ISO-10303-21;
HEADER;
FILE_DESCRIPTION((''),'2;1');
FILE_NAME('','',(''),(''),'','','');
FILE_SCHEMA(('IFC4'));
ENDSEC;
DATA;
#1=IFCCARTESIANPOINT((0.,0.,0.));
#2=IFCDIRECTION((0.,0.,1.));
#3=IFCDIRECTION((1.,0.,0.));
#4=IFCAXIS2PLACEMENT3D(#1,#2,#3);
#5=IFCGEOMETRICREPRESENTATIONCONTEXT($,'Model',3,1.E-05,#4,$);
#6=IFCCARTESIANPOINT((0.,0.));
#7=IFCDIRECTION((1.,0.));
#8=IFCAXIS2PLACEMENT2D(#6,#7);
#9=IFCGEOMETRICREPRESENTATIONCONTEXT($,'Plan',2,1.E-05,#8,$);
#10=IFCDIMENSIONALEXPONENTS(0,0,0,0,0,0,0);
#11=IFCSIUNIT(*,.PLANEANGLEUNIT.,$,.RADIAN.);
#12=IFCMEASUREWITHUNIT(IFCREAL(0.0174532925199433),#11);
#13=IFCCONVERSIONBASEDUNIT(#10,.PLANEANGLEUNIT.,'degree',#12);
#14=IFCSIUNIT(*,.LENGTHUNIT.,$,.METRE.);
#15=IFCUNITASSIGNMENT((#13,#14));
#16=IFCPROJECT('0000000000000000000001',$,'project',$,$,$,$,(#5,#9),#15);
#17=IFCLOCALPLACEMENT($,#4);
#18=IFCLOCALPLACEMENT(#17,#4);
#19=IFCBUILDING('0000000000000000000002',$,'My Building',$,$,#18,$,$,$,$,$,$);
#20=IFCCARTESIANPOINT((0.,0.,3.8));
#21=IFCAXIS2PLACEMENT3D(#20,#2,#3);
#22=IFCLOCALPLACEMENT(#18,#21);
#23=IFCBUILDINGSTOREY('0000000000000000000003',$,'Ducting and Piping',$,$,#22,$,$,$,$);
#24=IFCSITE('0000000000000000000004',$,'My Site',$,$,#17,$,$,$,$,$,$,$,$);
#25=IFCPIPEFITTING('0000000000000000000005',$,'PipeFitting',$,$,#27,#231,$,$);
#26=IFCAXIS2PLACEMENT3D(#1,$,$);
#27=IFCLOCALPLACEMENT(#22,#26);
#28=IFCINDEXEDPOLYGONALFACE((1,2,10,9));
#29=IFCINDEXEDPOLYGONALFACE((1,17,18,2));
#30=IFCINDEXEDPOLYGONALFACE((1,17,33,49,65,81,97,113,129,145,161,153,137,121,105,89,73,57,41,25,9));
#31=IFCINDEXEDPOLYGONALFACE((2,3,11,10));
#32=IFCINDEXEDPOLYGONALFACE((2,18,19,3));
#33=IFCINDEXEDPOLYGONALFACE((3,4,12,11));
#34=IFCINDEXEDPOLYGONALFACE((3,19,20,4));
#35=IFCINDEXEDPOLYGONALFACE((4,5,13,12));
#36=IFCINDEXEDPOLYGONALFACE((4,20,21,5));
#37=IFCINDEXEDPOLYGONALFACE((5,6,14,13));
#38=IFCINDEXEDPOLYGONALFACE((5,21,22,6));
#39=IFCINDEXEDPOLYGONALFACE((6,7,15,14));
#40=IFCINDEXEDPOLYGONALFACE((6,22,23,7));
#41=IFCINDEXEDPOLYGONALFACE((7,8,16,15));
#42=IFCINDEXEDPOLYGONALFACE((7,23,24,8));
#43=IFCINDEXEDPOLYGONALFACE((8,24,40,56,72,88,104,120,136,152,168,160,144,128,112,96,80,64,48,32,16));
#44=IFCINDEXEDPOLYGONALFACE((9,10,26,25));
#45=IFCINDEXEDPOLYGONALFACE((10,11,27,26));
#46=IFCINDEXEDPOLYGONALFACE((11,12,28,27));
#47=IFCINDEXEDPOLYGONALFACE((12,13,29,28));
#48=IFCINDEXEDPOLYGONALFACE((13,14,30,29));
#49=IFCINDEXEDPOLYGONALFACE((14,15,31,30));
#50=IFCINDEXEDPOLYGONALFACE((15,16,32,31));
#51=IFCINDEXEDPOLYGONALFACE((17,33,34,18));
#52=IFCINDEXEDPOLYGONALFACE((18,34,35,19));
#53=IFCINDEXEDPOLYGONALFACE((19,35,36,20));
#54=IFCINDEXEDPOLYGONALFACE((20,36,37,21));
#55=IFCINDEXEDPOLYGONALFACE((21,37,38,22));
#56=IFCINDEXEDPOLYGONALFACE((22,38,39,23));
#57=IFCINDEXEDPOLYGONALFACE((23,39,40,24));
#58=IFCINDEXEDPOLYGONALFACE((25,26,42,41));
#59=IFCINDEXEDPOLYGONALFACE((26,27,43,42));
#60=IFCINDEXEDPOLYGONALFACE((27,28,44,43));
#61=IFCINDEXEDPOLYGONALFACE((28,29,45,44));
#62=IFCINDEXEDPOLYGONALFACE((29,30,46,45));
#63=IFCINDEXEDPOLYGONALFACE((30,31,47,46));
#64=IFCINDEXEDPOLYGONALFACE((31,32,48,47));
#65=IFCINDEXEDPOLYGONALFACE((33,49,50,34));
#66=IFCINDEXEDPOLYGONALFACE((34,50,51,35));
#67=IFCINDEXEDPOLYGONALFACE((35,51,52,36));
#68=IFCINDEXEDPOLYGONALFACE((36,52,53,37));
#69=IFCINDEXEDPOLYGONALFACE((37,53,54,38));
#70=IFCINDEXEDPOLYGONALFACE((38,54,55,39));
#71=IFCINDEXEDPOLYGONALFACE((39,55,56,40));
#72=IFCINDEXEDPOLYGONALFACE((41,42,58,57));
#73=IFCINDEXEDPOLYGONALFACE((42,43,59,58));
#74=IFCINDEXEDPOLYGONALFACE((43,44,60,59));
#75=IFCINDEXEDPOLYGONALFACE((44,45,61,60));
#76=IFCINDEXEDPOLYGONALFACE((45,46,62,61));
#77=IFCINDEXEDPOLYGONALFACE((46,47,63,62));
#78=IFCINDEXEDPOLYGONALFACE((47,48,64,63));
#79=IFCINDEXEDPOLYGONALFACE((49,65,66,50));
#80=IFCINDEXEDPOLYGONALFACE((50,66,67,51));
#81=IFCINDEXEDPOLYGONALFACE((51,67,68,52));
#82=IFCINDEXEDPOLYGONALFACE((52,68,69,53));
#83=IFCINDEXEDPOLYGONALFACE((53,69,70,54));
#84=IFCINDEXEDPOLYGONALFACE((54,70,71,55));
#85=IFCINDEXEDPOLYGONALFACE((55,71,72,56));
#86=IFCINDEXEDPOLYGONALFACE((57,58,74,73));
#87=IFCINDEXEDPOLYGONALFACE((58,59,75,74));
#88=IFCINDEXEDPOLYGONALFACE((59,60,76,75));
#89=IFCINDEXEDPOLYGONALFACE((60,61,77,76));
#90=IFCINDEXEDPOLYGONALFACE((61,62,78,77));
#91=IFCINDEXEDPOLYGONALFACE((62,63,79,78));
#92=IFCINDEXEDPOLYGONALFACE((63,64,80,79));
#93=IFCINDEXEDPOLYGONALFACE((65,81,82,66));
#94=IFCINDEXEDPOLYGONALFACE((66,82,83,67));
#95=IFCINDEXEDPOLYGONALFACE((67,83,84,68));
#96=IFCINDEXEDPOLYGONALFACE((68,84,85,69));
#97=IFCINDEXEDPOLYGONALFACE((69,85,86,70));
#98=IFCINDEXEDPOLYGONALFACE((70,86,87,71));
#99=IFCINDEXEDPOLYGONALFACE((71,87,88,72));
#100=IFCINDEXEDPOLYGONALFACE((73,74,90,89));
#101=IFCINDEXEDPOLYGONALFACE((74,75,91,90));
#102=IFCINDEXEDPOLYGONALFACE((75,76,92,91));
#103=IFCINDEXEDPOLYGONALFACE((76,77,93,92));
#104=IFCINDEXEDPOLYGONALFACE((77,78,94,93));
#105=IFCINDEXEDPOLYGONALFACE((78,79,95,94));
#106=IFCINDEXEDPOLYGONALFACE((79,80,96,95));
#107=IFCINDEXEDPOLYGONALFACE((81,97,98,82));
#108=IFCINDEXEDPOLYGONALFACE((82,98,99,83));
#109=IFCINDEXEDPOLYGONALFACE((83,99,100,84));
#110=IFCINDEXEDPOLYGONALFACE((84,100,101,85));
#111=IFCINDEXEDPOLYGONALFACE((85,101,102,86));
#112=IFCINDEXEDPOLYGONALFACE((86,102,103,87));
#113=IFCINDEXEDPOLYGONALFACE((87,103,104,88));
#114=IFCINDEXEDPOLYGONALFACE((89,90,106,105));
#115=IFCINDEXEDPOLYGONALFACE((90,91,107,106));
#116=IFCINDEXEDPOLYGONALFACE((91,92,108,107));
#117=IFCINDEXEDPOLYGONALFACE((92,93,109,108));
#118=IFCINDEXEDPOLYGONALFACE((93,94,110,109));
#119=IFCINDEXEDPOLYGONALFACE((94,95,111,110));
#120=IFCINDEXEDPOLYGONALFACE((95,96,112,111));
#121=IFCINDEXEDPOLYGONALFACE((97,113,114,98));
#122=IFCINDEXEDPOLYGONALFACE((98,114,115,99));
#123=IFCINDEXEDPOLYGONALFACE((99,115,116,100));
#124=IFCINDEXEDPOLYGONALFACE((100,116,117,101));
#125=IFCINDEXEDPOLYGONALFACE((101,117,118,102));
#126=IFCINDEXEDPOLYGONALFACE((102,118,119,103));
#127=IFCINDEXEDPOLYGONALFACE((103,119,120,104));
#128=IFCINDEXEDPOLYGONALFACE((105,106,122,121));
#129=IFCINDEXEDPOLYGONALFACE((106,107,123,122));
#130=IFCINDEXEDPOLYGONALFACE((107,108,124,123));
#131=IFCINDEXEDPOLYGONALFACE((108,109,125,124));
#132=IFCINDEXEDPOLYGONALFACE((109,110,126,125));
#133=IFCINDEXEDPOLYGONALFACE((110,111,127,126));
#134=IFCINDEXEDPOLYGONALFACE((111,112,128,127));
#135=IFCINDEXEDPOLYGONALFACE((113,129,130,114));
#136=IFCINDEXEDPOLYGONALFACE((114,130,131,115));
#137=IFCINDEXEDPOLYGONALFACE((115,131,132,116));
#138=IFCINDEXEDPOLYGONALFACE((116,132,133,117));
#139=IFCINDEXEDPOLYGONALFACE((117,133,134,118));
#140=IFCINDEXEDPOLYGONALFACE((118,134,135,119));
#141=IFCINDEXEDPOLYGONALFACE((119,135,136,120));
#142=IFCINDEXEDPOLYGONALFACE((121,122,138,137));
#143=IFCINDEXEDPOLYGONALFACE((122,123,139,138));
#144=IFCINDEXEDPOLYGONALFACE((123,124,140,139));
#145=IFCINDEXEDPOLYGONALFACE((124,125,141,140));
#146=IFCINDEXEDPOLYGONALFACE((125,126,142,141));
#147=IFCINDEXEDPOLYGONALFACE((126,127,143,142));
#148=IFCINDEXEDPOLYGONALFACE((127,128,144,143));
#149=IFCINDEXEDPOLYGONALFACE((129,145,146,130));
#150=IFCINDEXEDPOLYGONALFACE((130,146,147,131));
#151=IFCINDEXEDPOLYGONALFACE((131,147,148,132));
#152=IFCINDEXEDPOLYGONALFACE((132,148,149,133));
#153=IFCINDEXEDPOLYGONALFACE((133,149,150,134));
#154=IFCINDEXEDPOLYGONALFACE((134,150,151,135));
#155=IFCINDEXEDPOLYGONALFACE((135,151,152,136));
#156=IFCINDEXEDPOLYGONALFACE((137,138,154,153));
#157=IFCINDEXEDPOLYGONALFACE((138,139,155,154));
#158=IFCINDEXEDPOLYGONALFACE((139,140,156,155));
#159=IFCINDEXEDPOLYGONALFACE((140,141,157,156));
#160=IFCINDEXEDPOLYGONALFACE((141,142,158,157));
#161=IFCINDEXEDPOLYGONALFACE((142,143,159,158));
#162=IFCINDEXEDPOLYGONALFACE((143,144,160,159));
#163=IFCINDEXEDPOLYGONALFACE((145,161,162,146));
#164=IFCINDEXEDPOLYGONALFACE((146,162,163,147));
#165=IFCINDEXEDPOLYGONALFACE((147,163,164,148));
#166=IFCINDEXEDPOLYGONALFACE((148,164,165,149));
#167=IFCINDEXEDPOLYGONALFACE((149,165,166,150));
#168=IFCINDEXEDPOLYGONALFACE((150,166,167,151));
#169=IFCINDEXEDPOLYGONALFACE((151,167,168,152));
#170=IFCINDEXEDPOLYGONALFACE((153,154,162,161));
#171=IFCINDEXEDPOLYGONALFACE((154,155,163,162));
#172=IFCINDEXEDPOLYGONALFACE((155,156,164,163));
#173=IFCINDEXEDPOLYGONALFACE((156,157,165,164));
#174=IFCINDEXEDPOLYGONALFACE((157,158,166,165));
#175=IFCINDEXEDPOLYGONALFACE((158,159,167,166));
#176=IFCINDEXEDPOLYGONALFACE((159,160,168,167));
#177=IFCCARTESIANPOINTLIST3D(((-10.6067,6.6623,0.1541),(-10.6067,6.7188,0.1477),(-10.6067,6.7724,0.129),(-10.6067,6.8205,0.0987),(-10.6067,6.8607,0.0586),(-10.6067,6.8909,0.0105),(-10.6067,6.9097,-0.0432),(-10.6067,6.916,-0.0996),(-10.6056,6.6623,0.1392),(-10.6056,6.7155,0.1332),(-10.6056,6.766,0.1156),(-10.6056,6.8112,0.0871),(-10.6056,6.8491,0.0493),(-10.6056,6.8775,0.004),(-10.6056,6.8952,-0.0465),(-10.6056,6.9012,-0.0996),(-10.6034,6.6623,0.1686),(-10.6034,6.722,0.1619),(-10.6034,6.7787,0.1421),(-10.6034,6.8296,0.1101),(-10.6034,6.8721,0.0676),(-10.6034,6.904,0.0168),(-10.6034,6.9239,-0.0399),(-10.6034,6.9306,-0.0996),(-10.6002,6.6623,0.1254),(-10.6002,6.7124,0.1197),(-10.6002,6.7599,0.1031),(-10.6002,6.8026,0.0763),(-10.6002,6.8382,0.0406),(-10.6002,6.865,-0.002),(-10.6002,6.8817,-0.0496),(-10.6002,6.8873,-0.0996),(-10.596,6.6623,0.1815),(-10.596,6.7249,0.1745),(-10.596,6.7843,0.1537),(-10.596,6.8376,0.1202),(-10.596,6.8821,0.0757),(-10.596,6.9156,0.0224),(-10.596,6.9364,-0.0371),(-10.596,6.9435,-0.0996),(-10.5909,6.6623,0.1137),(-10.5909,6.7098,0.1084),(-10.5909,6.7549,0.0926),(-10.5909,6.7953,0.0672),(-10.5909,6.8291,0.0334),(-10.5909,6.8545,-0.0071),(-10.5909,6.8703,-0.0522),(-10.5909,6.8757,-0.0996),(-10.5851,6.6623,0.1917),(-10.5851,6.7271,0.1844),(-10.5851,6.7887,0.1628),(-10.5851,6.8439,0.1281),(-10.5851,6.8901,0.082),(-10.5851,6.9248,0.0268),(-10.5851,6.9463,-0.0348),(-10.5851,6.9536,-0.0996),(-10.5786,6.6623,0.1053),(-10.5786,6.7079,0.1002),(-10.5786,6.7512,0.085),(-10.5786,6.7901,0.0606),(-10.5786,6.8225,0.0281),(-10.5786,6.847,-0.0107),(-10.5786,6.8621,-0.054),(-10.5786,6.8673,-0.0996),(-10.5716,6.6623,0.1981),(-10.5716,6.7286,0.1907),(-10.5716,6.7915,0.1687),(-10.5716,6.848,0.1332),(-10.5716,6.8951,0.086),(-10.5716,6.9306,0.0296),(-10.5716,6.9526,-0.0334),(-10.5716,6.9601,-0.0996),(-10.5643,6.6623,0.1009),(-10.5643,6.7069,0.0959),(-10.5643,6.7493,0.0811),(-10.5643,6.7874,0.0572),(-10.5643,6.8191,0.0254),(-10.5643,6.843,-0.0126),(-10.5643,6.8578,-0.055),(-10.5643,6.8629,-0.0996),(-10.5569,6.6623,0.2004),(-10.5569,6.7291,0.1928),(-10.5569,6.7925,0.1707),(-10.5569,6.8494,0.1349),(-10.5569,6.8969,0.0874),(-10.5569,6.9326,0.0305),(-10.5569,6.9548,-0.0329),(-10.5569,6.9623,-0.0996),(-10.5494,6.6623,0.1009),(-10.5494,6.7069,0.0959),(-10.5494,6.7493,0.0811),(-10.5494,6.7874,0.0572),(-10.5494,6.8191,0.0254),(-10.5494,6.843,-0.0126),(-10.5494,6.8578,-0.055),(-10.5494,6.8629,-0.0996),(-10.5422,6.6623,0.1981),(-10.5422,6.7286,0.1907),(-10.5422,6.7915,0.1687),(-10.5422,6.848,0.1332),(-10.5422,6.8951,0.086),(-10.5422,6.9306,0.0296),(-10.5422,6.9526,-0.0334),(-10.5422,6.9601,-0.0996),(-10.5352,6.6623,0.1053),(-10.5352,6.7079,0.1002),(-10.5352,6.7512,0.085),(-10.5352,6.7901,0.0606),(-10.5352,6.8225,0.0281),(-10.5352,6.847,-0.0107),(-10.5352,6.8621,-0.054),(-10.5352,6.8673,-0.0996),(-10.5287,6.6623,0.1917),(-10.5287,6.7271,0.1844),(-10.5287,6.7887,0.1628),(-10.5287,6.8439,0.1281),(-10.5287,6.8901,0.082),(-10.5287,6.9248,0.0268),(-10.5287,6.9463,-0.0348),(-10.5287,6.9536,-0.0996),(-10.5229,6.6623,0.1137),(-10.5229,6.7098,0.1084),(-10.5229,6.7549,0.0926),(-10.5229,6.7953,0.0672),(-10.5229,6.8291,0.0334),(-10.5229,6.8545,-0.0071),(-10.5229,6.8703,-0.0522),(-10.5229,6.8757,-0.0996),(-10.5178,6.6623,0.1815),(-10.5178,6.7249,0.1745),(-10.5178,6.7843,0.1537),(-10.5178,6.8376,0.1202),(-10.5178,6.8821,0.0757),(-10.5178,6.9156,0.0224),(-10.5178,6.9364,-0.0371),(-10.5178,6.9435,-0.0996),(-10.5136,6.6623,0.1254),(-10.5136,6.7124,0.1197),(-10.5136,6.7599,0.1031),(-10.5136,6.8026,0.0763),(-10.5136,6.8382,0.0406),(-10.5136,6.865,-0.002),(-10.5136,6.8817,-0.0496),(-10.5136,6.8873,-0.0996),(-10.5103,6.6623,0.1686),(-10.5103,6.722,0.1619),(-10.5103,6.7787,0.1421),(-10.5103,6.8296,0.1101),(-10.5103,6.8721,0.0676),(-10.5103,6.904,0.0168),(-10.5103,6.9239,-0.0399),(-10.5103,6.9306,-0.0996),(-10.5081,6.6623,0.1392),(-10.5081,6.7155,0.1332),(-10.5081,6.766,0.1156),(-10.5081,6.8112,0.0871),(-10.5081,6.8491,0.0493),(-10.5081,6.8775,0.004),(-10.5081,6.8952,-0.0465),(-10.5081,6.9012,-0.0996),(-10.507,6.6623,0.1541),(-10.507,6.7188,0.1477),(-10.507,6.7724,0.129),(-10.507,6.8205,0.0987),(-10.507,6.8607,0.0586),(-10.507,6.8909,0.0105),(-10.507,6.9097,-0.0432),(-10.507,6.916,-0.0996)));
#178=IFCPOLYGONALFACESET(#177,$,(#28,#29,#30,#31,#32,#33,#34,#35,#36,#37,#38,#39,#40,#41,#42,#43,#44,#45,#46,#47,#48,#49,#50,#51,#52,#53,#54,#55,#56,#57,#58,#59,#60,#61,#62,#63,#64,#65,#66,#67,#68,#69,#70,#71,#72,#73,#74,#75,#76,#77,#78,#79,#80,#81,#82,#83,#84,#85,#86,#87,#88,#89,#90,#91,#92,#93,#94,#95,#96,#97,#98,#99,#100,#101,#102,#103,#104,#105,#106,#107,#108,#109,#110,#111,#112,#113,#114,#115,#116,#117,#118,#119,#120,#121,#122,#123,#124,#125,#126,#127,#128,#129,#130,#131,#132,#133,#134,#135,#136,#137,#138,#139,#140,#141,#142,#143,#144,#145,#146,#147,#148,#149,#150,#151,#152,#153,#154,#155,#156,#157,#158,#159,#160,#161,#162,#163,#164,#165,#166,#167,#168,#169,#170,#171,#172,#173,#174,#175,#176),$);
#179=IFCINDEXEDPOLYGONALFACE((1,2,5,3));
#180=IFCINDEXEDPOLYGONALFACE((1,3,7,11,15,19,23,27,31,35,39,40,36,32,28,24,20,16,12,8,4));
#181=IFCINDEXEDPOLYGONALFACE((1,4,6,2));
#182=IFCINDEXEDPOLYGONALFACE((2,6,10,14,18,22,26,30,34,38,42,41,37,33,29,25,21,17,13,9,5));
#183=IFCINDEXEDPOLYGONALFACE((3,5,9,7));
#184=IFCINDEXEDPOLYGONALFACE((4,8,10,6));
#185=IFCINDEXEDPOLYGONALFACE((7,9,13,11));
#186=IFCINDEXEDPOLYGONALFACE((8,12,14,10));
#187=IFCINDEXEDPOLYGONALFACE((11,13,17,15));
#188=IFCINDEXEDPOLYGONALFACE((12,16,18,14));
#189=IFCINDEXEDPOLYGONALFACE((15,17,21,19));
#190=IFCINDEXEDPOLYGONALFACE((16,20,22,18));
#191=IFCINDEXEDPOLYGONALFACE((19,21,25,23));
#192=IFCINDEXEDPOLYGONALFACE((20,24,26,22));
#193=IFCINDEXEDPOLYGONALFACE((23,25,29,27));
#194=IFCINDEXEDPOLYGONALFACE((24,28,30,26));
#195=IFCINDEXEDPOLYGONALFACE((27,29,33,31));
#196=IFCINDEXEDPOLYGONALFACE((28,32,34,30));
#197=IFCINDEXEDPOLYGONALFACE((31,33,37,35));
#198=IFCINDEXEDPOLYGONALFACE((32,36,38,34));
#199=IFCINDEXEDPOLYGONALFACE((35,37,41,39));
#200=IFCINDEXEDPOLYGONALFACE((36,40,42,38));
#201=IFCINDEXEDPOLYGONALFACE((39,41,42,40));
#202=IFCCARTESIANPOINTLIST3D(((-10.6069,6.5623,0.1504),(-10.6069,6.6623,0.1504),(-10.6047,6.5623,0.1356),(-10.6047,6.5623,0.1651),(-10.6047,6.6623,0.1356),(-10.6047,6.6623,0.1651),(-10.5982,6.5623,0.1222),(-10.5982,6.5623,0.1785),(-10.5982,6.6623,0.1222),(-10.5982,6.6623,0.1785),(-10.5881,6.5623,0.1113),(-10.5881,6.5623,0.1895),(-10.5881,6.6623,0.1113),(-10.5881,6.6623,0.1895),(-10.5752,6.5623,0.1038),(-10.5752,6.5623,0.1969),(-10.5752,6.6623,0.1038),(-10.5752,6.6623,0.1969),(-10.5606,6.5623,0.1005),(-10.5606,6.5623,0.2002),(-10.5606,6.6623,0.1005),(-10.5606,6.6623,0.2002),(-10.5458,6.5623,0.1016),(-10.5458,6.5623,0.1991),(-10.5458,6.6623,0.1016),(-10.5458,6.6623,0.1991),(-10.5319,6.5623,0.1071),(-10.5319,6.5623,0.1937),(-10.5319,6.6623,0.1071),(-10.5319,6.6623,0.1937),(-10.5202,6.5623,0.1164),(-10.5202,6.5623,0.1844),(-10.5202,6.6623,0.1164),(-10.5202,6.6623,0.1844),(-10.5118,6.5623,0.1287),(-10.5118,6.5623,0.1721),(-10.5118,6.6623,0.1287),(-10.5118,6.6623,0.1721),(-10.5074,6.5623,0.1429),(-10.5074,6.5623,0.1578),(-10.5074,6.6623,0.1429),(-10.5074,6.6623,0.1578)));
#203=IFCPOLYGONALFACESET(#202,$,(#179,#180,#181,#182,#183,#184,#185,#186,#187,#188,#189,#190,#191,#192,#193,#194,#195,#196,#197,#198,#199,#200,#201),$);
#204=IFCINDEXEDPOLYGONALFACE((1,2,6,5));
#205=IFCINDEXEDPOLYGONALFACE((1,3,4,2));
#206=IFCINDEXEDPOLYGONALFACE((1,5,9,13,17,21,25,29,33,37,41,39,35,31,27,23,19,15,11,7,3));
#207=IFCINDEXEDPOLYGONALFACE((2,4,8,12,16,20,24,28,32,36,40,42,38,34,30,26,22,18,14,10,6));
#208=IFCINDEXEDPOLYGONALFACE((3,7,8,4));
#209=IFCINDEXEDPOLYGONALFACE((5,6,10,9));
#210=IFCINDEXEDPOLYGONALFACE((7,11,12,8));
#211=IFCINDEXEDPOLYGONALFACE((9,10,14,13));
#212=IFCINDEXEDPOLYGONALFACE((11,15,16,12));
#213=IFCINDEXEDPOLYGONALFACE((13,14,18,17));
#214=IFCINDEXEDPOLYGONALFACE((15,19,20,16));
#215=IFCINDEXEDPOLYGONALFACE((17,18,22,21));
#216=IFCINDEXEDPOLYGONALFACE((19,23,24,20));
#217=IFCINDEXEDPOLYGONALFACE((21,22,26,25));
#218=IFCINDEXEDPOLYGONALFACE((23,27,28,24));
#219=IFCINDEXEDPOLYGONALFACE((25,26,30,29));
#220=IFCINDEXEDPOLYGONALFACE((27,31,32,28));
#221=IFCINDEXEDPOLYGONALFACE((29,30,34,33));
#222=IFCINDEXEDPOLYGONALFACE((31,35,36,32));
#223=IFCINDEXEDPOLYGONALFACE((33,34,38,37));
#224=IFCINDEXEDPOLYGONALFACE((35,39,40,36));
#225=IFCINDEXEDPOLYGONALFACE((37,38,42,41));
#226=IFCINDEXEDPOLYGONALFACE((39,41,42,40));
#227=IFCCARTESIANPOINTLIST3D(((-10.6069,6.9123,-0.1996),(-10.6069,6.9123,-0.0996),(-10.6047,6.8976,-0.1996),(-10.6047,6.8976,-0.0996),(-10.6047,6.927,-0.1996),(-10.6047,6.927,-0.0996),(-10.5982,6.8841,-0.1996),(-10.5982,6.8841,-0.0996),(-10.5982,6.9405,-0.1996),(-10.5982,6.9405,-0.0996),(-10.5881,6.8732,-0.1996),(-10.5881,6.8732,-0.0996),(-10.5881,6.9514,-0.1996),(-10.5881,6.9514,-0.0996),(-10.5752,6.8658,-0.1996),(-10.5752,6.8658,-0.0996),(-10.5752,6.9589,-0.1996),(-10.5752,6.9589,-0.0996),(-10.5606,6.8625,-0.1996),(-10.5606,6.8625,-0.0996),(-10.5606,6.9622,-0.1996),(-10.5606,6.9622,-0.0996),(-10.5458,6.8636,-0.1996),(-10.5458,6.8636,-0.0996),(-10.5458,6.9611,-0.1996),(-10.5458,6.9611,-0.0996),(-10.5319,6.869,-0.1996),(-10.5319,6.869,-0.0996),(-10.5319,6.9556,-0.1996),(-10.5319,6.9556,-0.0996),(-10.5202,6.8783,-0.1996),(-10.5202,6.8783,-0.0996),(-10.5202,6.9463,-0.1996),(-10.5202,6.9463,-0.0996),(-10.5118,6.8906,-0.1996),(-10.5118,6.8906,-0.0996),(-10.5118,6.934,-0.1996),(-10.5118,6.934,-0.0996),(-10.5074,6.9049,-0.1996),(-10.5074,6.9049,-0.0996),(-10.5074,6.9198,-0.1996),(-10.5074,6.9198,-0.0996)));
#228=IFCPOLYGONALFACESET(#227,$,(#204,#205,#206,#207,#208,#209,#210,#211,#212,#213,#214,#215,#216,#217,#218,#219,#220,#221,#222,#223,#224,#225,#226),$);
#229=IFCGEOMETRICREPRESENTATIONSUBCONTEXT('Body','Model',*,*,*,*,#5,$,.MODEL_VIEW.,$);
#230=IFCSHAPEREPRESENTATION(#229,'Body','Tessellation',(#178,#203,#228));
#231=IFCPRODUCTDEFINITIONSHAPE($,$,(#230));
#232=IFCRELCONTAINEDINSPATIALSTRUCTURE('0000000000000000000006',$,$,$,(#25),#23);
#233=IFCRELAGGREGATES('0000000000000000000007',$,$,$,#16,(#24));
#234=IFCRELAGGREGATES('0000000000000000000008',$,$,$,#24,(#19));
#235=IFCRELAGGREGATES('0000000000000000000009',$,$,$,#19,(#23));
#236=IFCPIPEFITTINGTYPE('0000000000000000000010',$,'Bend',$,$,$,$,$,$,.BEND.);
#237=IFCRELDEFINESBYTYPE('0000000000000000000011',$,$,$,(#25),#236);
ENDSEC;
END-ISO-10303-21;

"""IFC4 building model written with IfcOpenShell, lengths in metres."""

from ifc_helpers import new_model, entity, si_unit, converted_unit, frame, origin_with_axes, origin_2d_with_axis, place, context, subcontext, project, spatial, circle, extrude, source, transform, mapped, type_object, type_shapes, element, save


model = new_model("IFC4")

# Units and contexts
model_context = context("Model", 3, precision=1e-05, world=origin_with_axes())
plan_context = context("Plan", 2, precision=1e-05, world=origin_2d_with_axis())
body_context = subcontext(model_context, "Body", "Model", "MODEL_VIEW")
ifc_project = project(units=[converted_unit("PLANEANGLEUNIT", "degree", entity("IfcReal", 0.0174532925199433), si_unit("PLANEANGLEUNIT", "RADIAN"), dimensions=[0, 0, 0, 0, 0, 0, 0]), si_unit("LENGTHUNIT", "METRE")], contexts=[model_context, plan_context])

# Site, building, storey
site_placement = place(None, origin_with_axes())
site = spatial("IfcSite", under=ifc_project, at=site_placement, Name="My Site")
building_placement = place(site_placement, origin_with_axes())
building = spatial("IfcBuilding", under=site, at=building_placement, Name="My Building")
storey_placement = place(building_placement, frame((0.0, 0.0, 3.8), z_axis=(0.0, 0.0, 1.0), x_axis=(1.0, 0.0, 0.0)))
storey = spatial("IfcBuildingStorey", under=building, at=storey_placement, Name="Ducting and Piping")

# Pipe fitting
pipe_fitting_type = type_object("IfcPipeFittingType", Name="Bend", PredefinedType="BEND")
shared_shape = source(origin_with_axes(), body_context, "Body", "SolidModel", [
    entity("IfcSweptDiskSolid", entity("IfcIndexedPolyCurve", entity("IfcCartesianPointList3D", [[0.0, 0.0, 0.1], [0.0, -0.0732, 0.2768], [0.0, -0.25, 0.35]]), [entity("IfcArcIndex", [1, 2, 3])]), 0.05),
    extrude(circle(Radius=0.05), origin_with_axes(), (0.0, 0.0, 1.0), 0.1),
    extrude(circle(Radius=0.05), frame((0.0, -0.25, 0.35), z_axis=(0.0, -1.0, 0.0), x_axis=(1.0, 0.0, 0.0)), (0.0, 0.0, 1.0), 0.1),
])
type_shapes(pipe_fitting_type, [shared_shape])
for number, where, z_axis, x_axis, name in (
    (1, (-10.5569, 6.5623, 0.1504), (0.0, 1.0, 0.0), (-1.0, 0.0, 0.0), "PipeFitting"),
):
    element("IfcPipeFitting", number, at=place(storey_placement, frame(where, z_axis=z_axis, x_axis=x_axis)), inside=storey, type_object=pipe_fitting_type, Name=name, context=body_context, shape_type="MappedRepresentation", body=[
        mapped(shared_shape, transform((0.0, 0.0, 0.0), x_axis=(1.0, 0.0, 0.0), y_axis=(0.0, 1.0, 0.0), z_axis=(0.0, 0.0, 1.0), scale=1.0)),
    ])

save(model, "model.ifc")
